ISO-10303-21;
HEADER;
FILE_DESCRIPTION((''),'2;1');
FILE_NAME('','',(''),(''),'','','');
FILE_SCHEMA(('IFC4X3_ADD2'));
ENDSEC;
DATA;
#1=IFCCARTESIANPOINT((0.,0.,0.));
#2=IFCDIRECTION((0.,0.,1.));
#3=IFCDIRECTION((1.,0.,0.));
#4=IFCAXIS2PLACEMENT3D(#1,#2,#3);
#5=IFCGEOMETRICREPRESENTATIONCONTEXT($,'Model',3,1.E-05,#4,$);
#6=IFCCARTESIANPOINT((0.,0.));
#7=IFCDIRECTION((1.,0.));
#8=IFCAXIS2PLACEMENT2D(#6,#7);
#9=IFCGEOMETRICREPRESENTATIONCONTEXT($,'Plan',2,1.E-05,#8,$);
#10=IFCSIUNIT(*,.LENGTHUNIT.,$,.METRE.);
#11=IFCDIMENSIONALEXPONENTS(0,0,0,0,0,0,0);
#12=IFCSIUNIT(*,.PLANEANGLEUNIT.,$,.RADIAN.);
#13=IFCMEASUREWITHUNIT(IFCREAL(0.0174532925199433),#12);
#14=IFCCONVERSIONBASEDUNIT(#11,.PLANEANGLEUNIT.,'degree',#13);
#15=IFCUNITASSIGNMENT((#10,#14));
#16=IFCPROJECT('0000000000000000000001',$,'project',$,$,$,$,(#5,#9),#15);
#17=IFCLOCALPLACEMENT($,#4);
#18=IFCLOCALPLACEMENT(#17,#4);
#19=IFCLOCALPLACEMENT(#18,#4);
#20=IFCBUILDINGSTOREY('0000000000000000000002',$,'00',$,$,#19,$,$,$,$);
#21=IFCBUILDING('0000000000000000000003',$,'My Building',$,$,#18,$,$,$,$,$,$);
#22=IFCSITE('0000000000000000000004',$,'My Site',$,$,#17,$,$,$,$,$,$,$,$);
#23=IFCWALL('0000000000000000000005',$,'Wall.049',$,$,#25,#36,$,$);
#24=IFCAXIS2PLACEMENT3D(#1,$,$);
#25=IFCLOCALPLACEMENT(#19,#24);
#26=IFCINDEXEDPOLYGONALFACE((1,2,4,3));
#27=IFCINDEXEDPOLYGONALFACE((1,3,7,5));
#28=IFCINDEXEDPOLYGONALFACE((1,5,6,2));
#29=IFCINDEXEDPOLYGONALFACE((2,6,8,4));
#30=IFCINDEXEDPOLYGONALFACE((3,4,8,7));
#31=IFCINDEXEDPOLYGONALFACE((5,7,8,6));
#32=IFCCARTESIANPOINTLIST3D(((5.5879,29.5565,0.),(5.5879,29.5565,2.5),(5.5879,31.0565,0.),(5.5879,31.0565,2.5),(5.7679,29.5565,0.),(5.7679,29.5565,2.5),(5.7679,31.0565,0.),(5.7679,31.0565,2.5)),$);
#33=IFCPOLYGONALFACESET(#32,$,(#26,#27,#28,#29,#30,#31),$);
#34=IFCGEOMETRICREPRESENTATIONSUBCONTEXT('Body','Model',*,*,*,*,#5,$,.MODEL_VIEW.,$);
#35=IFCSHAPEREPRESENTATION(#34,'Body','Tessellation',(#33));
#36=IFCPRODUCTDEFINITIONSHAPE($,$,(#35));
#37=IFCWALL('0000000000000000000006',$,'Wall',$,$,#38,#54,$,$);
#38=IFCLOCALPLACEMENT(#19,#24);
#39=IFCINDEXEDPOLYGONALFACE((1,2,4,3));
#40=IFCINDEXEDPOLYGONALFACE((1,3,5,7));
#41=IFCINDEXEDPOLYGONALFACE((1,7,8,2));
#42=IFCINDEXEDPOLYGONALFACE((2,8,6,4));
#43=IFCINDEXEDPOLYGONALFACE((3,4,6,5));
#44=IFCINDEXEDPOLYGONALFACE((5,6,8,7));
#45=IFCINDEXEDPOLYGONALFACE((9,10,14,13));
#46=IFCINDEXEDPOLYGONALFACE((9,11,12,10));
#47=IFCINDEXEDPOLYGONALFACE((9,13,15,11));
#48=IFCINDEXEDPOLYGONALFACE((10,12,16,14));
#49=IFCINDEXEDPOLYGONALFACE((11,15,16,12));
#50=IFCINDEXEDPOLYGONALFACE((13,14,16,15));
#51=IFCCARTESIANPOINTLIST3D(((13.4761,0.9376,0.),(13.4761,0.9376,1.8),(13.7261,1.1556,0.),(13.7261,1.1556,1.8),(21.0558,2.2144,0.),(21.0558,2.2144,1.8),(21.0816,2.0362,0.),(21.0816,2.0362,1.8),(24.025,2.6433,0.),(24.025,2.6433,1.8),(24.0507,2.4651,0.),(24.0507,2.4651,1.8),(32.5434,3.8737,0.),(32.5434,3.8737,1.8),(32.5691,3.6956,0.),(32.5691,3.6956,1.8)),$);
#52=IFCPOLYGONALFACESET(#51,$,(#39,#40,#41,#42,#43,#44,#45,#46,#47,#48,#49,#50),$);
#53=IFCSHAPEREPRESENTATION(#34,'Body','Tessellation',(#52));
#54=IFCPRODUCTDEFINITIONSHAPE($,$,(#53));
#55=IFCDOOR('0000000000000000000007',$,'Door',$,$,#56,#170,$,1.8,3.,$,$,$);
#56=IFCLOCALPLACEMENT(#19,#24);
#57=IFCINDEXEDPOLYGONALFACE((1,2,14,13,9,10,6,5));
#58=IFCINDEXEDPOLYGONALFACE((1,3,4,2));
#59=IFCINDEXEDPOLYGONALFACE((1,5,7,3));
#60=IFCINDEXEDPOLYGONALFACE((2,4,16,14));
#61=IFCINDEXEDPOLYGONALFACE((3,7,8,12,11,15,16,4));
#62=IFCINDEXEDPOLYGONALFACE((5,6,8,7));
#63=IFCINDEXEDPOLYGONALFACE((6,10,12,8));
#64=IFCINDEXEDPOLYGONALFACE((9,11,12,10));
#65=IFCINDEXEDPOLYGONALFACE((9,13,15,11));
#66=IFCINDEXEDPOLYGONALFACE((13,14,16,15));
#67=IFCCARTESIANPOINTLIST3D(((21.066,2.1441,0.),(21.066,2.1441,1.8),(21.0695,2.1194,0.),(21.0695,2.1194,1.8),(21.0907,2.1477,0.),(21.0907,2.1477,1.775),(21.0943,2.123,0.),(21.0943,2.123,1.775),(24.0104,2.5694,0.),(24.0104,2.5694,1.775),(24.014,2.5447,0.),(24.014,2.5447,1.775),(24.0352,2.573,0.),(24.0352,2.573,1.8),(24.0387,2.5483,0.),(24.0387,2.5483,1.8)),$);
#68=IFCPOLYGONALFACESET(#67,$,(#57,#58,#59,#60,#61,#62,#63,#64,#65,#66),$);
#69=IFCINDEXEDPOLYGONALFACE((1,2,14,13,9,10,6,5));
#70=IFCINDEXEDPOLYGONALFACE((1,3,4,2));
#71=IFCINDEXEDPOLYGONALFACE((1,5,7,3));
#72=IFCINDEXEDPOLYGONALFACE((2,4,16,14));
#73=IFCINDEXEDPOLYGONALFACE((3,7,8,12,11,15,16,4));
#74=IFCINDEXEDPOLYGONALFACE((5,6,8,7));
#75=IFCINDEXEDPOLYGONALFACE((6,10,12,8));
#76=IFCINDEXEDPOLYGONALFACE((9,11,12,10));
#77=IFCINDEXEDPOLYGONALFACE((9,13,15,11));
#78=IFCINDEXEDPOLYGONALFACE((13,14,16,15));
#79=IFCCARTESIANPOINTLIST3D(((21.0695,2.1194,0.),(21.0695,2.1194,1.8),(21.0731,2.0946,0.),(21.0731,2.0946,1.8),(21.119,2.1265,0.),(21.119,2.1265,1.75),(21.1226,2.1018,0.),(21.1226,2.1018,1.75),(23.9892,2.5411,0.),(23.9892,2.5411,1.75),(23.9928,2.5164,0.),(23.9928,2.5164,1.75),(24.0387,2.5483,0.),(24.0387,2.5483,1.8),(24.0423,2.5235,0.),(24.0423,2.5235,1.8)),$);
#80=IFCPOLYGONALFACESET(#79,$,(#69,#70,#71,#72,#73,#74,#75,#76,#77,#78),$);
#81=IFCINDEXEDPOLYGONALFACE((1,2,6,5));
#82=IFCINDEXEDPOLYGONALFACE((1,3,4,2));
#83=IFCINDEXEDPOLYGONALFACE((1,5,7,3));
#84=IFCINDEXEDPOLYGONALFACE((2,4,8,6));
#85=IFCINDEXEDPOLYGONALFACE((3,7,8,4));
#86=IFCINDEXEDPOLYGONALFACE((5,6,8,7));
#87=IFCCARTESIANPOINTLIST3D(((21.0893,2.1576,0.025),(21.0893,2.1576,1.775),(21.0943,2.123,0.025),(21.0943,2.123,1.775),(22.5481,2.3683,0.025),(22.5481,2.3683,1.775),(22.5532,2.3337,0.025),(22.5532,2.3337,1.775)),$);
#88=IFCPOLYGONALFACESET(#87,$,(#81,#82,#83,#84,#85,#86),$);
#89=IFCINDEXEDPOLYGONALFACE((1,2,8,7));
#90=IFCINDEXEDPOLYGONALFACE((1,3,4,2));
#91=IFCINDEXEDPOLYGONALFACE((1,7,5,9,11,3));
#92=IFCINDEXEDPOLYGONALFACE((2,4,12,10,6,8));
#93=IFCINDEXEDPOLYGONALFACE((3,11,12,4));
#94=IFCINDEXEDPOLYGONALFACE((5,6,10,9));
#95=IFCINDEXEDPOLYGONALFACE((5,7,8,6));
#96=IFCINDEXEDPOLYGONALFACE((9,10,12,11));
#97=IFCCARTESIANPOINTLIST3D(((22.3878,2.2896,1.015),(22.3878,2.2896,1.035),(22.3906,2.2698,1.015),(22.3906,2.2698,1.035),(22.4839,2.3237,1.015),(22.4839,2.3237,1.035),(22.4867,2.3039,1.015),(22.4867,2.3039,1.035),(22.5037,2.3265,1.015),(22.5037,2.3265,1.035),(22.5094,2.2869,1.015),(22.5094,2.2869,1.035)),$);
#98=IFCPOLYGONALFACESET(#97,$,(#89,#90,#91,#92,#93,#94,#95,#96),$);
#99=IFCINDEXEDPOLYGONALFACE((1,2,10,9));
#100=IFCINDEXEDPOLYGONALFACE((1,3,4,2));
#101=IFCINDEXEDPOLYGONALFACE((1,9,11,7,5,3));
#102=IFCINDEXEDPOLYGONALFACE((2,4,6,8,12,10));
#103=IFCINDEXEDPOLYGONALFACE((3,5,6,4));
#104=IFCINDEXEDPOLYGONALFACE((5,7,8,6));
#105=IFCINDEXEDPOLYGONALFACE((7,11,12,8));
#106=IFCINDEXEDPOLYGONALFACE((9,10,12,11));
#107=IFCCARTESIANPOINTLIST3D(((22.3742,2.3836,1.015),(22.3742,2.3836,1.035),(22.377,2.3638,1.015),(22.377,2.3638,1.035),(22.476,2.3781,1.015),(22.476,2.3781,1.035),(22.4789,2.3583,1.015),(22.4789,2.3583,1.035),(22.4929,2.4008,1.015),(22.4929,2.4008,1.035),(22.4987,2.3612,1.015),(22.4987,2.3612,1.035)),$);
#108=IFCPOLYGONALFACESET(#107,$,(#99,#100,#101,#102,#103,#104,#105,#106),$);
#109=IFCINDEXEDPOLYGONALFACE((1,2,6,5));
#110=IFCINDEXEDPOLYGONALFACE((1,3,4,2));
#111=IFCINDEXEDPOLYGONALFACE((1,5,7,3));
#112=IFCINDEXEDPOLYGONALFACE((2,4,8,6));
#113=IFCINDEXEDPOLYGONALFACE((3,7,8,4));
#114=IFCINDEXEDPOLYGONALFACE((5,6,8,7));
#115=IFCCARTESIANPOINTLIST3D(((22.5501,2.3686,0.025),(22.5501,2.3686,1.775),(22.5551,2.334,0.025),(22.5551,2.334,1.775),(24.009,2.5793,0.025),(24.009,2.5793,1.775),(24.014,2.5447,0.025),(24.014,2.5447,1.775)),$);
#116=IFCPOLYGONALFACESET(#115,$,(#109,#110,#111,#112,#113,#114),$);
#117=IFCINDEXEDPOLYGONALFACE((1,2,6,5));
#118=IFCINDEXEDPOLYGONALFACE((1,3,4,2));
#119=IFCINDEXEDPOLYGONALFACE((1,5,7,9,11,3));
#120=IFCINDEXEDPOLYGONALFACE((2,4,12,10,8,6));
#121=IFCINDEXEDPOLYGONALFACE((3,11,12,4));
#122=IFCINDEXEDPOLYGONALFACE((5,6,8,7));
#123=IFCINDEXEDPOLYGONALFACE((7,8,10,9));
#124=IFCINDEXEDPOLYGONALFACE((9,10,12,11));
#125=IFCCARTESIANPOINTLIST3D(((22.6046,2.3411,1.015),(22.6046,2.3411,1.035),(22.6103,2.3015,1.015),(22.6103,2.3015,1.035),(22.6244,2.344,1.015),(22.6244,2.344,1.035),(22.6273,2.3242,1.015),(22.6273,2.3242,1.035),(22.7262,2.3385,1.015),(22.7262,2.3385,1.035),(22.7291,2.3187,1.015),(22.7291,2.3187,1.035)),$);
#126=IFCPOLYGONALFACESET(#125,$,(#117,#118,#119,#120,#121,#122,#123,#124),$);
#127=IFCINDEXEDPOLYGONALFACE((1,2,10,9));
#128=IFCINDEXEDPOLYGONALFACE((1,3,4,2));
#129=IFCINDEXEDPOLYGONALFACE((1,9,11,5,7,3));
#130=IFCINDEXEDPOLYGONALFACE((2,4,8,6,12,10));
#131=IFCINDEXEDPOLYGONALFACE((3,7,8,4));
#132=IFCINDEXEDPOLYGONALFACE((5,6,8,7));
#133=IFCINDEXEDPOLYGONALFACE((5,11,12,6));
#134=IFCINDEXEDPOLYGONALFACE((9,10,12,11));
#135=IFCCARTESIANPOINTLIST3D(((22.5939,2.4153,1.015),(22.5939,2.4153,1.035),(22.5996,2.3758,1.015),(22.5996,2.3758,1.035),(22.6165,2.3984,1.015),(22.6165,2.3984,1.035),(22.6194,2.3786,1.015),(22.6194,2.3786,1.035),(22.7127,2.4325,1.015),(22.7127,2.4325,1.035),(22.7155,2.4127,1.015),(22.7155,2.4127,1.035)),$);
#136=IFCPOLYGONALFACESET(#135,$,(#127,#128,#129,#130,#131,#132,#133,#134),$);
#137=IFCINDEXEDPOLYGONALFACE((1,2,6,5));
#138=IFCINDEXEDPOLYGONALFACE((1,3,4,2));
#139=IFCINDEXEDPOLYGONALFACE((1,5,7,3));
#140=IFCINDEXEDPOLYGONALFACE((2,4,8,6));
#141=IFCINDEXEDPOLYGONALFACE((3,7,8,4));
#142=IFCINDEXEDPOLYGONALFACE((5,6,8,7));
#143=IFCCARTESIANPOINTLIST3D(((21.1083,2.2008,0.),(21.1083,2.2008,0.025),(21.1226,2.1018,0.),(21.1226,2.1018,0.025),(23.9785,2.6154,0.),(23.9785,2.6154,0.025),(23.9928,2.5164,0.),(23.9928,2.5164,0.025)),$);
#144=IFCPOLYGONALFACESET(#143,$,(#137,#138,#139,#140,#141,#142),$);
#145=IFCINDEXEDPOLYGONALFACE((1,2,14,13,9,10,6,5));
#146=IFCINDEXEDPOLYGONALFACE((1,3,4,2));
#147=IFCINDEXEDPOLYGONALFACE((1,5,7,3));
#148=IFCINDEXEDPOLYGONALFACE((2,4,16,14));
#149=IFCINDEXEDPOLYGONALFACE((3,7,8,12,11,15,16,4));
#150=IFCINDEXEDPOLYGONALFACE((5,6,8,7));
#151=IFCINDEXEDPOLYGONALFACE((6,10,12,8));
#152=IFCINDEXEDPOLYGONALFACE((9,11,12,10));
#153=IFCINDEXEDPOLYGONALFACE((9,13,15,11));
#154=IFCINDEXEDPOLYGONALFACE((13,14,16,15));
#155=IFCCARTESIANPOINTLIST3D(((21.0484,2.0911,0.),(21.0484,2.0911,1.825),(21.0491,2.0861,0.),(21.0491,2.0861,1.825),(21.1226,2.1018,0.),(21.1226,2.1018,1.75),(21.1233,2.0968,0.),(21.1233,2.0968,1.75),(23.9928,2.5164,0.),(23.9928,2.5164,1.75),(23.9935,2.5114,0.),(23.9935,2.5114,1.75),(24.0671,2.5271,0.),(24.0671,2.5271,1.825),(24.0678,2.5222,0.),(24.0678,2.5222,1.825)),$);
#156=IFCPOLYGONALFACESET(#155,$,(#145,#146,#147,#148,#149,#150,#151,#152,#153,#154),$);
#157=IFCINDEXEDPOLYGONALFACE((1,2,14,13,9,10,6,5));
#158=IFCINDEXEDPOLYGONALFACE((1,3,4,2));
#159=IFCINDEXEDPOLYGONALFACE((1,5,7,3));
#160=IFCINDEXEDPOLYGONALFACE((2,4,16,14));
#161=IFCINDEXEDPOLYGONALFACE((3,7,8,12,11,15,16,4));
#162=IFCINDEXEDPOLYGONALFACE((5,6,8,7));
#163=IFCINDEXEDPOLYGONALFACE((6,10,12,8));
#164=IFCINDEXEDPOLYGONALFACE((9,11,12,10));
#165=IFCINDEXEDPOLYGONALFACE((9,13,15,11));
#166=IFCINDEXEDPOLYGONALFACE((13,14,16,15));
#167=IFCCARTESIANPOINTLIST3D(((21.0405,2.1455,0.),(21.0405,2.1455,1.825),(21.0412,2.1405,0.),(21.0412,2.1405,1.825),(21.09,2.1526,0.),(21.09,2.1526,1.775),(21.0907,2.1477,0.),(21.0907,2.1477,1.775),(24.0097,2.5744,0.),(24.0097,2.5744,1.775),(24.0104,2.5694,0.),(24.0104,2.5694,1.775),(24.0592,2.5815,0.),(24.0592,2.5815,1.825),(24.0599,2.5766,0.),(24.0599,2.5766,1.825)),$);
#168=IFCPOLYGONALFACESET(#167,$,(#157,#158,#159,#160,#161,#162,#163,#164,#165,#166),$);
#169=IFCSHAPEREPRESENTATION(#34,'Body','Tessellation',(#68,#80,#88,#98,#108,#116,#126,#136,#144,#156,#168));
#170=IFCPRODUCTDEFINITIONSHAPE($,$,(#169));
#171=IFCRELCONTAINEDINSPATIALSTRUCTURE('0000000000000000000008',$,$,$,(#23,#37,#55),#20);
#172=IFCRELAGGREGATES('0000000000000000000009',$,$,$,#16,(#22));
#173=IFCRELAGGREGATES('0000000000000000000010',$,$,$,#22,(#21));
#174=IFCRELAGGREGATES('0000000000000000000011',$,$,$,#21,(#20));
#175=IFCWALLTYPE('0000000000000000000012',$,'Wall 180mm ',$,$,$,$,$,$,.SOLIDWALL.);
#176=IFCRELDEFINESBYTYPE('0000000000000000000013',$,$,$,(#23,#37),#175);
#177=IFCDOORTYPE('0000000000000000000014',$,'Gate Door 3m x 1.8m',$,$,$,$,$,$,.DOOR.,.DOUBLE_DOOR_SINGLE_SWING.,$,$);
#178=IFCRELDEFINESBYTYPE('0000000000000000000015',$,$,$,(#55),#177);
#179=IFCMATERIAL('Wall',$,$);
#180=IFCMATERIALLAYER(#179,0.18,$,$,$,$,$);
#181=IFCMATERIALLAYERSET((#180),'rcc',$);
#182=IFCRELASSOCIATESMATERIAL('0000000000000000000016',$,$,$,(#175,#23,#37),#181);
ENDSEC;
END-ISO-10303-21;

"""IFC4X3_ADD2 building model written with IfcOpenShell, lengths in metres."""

from ifc_helpers import new_model, entity, si_unit, converted_unit, frame, origin_with_axes, origin_2d_with_axis, place, context, subcontext, project, spatial, line, indexed_curve, outline, extrude, shape, source, transform, mapped, material, layer, layer_set, layer_usage, type_object, type_shapes, element, fill, save


model = new_model("IFC4X3_ADD2")

# Units and contexts
model_context = context("Model", 3, precision=1e-05, world=origin_with_axes())
plan_context = context("Plan", 2, precision=1e-05, world=origin_2d_with_axis())
body_context_1 = subcontext(model_context, "Body", "Model", "MODEL_VIEW")
body_context_2 = subcontext(plan_context, "Body", "Plan", "PLAN_VIEW")
ifc_project = project(units=[si_unit("LENGTHUNIT", "METRE"), converted_unit("PLANEANGLEUNIT", "degree", entity("IfcReal", 0.0174532925199433), si_unit("PLANEANGLEUNIT", "RADIAN"), dimensions=[0, 0, 0, 0, 0, 0, 0])], contexts=[model_context, plan_context])

# Site, building, storey
site_placement = place(None, origin_with_axes())
site = spatial("IfcSite", under=ifc_project, at=site_placement, Name="My Site")
building_placement = place(site_placement, origin_with_axes())
building = spatial("IfcBuilding", under=site, at=building_placement, Name="My Building")
storey_placement = place(building_placement, origin_with_axes())
storey = spatial("IfcBuildingStorey", under=building, at=storey_placement, Name="00")

# Shared definitions
ifc_material_1 = material(Name="Wall")
ifc_layer_1 = layer(ifc_material_1, 0.18)
ifc_layer_set_1 = layer_set([ifc_layer_1], Name="rcc")
wall_type_1 = type_object("IfcWallType", Name="Wall 180mm ", PredefinedType="SOLIDWALL", material=ifc_layer_set_1)

# Wall
ifc_layer_usage_1 = layer_usage(ifc_layer_set_1, "AXIS2", "POSITIVE", 0.0)
wall_1_placement = place(storey_placement, frame((5.7679, 29.5565, 0.0), z_axis=(0.0, 0.0, 1.0), x_axis=(0.0, 1.0, 0.0)))
element("IfcWall", 1, at=wall_1_placement, inside=storey, type_object=wall_type_1, material=ifc_layer_usage_1, Name="Wall.049", context=body_context_1, shape_type="SweptSolid", body=[
    extrude(outline(indexed_curve([(0.0, 0.0), (0.0, 0.18), (1.5, 0.18), (1.5, 0.0), (0.0, 0.0)], self_intersect=False)), origin_with_axes(), (0.0, 0.0, 1.0), 2.5),
])

# Wall, opening, door
ifc_layer_usage_2 = layer_usage(ifc_layer_set_1, "AXIS2", "POSITIVE", 0.0)
wall_2_placement = place(storey_placement, frame((13.7261, 0.9737, 0.0), z_axis=(0.0, 0.0, 1.0), x_axis=(0.989728, 0.142965, 0.0)))
wall_2 = element("IfcWall", 2, at=wall_2_placement, inside=storey, type_object=wall_type_1, material=ifc_layer_usage_2, Name="Wall", context=body_context_1, shape_type="SweptSolid", body=[
    extrude(outline(indexed_curve([(-0.2526, 0.0), (0.026, 0.18), (19.0386, 0.18), (19.0386, 0.0)], segments=[line(1, 2, 3, 4, 1)])), origin_with_axes(), (0.0, 0.0, 1.0), 1.8),
])
shared_shape_1 = source(origin_with_axes(), body_context_1, "Body", "SweptSolid", [
    extrude(outline(indexed_curve([(0.0, 0.0), (3.0, 0.0), (3.0, 1.8), (0.0, 1.8)], segments=[line(1, 2, 3, 4, 1)])), frame((0.0, -0.6, 0.0), z_axis=(0.0, -1.0, 0.0), x_axis=(1.0, 0.0, 0.0)), (0.0, 0.0, -1.0), 1.2),
])
opening_1_placement = place(wall_2_placement, frame((7.4318, 0.059, 0.0), z_axis=(0.0, 0.0, 1.0), x_axis=(1.0, 0.0, 0.0)))
opening_1 = element("IfcOpeningElement", 3, at=opening_1_placement, cuts=wall_2, PredefinedType="OPENING", context=body_context_1, shape_type="MappedRepresentation", body=[
    mapped(shared_shape_1, transform((0.0, 0.0, 0.0), x_axis=(1.0, 0.0, 0.0), y_axis=(0.0, 1.0, 0.0), z_axis=(0.0, 0.0, 1.0), scale=1.0)),
])
door_type_1 = type_object("IfcDoorType", Name="Gate Door 3m x 1.8m", OperationType="DOUBLE_DOOR_SINGLE_SWING", PredefinedType="DOOR")
shared_shape_2 = source(origin_with_axes(), body_context_1, "Body", "SweptSolid", [
    extrude(outline(indexed_curve([(0.0, 0.0), (0.0, 1.8), (3.0, 1.8), (3.0, 0.0), (2.975, 0.0), (2.975, 1.775), (0.025, 1.775), (0.025, 0.0)], segments=[line(1, 2, 3, 4, 5, 6, 7, 8, 1)])), frame((0.0, 0.025, 0.0), z_axis=(0.0, -1.0, 0.0), x_axis=(1.0, 0.0, 0.0)), (0.0, 0.0, -1.0), 0.025),
    extrude(outline(indexed_curve([(0.0, 0.0), (0.0, 1.8), (3.0, 1.8), (3.0, 0.0), (2.95, 0.0), (2.95, 1.75), (0.05, 1.75), (0.05, 0.0)], segments=[line(1, 2, 3, 4, 5, 6, 7, 8, 1)])), frame((0.0, 0.0, 0.0), z_axis=(0.0, -1.0, 0.0), x_axis=(1.0, 0.0, 0.0)), (0.0, 0.0, -1.0), 0.025),
    extrude(outline(indexed_curve([(0.0, 0.0), (1.474, 0.0), (1.474, 0.035), (0.0, 0.035)], segments=[line(1, 2, 3, 4, 1)])), frame((0.025, 0.025, 0.025), z_axis=(0.0, 0.0, 1.0), x_axis=(1.0, 0.0, 0.0)), (0.0, 0.0, 1.0), 1.75),
    extrude(outline(indexed_curve([(0.0, 0.0), (0.0, -0.04), (-0.12, -0.04), (-0.12, -0.02), (-0.02, -0.02), (-0.02, 0.0)], segments=[line(1, 2, 3, 4, 5, 6, 1)])), frame((1.449, 0.025, 1.015), z_axis=(0.0, 0.0, 1.0), x_axis=(1.0, 0.0, 0.0)), (0.0, 0.0, 1.0), 0.02),
    extrude(outline(indexed_curve([(0.0, 0.0), (0.0, 0.04), (-0.12, 0.04), (-0.12, 0.02), (-0.02, 0.02), (-0.02, 0.0)], segments=[line(1, 2, 3, 4, 5, 6, 1)])), frame((1.449, 0.06, 1.015), z_axis=(0.0, 0.0, 1.0), x_axis=(1.0, 0.0, 0.0)), (0.0, 0.0, 1.0), 0.02),
    extrude(outline(indexed_curve([(0.0, 0.0), (-1.474, 0.0), (-1.474, 0.035), (0.0, 0.035)], segments=[line(1, 2, 3, 4, 1)])), frame((2.975, 0.025, 0.025), z_axis=(0.0, 0.0, 1.0), x_axis=(1.0, 0.0, 0.0)), (0.0, 0.0, 1.0), 1.75),
    extrude(outline(indexed_curve([(0.0, 0.0), (0.0, -0.04), (0.12, -0.04), (0.12, -0.02), (0.02, -0.02), (0.02, 0.0)], segments=[line(1, 2, 3, 4, 5, 6, 1)])), frame((1.551, 0.025, 1.015), z_axis=(0.0, 0.0, 1.0), x_axis=(1.0, 0.0, 0.0)), (0.0, 0.0, 1.0), 0.02),
    extrude(outline(indexed_curve([(0.0, 0.0), (0.0, 0.04), (0.12, 0.04), (0.12, 0.02), (0.02, 0.02), (0.02, 0.0)], segments=[line(1, 2, 3, 4, 5, 6, 1)])), frame((1.551, 0.06, 1.015), z_axis=(0.0, 0.0, 1.0), x_axis=(1.0, 0.0, 0.0)), (0.0, 0.0, 1.0), 0.02),
    extrude(outline(indexed_curve([(0.0, 0.0), (2.9, 0.0), (2.9, 0.1), (0.0, 0.1)], segments=[line(1, 2, 3, 4, 1)])), frame((0.05, 0.0, 0.0), z_axis=(0.0, 0.0, 1.0), x_axis=(1.0, 0.0, 0.0)), (0.0, 0.0, 1.0), 0.025),
    extrude(outline(indexed_curve([(0.0, 0.0), (0.0, 1.825), (3.05, 1.825), (3.05, 0.0), (2.975, 0.0), (2.975, 1.75), (0.075, 1.75), (0.075, 0.0)], segments=[line(1, 2, 3, 4, 5, 6, 7, 8, 1)])), frame((-0.025, -0.005, 0.0), z_axis=(0.0, -1.0, 0.0), x_axis=(1.0, 0.0, 0.0)), (0.0, 0.0, -1.0), 0.005),
    extrude(outline(indexed_curve([(0.0, 0.0), (0.0, 1.825), (3.05, 1.825), (3.05, 0.0), (3.0, 0.0), (3.0, 1.775), (0.05, 1.775), (0.05, 0.0)], segments=[line(1, 2, 3, 4, 5, 6, 7, 8, 1)])), frame((-0.025, 0.05, 0.0), z_axis=(0.0, -1.0, 0.0), x_axis=(1.0, 0.0, 0.0)), (0.0, 0.0, -1.0), 0.005),
])
shared_shape_3 = source(origin_with_axes(), body_context_2, "Body", "Curve2D", [
    entity("IfcIndexedPolyCurve", entity("IfcCartesianPointList2D", [[0.0, 0.0], [0.0, 0.05], [0.025, 0.05], [0.025, 0.025], [0.05, 0.025], [0.05, 0.0]]), [entity("IfcLineIndex", [1, 2, 3, 4, 5, 6, 1])]),
    entity("IfcIndexedPolyCurve", entity("IfcCartesianPointList2D", [[3.0, 0.0], [3.0, 0.05], [2.975, 0.05], [2.975, 0.025], [2.95, 0.025], [2.95, 0.0]]), [entity("IfcLineIndex", [1, 2, 3, 4, 5, 6, 1])]),
    entity("IfcTrimmedCurve", entity("IfcEllipse", entity("IfcAxis2Placement2D", entity("IfcCartesianPoint", [0.06, 0.05]), entity("IfcDirection", [1.0, 0.0])), 1.44, 1.475), [entity("IfcCartesianPoint", [1.5, 0.05])], [entity("IfcCartesianPoint", [0.06, 1.525])], True, "CARTESIAN"),
    entity("IfcIndexedPolyCurve", entity("IfcCartesianPointList2D", [[0.025, 0.05], [0.06, 0.05], [0.06, 1.525], [0.025, 1.525]]), [entity("IfcLineIndex", [1, 2, 3, 4, 1])]),
    entity("IfcTrimmedCurve", entity("IfcEllipse", entity("IfcAxis2Placement2D", entity("IfcCartesianPoint", [2.94, 0.05]), entity("IfcDirection", [1.0, 0.0])), 1.44, 1.475), [entity("IfcCartesianPoint", [2.94, 1.525])], [entity("IfcCartesianPoint", [1.5, 0.05])], True, "CARTESIAN"),
    entity("IfcIndexedPolyCurve", entity("IfcCartesianPointList2D", [[2.975, 0.05], [2.94, 0.05], [2.94, 1.525], [2.975, 1.525]]), [entity("IfcLineIndex", [1, 2, 3, 4, 1])]),
])
type_shapes(door_type_1, [shared_shape_2, shared_shape_3])
door_1_placement = place(opening_1_placement, frame((0.0, 0.0, 0.0), z_axis=(0.0, 0.0, 1.0), x_axis=(1.0, 0.0, 0.0)))
door_1 = element("IfcDoor", 4, at=door_1_placement, inside=storey, type_object=door_type_1, Name="Door", OverallHeight=1.8, OverallWidth=3.0, shapes=[
    shape(body_context_1, "Body", "MappedRepresentation", [mapped(shared_shape_2, transform((0.0, 0.0, 0.0), x_axis=(1.0, 0.0, 0.0), y_axis=(0.0, 1.0, 0.0), z_axis=(0.0, 0.0, 1.0), scale=1.0))]),
    shape(body_context_2, "Body", "MappedRepresentation", [mapped(shared_shape_3, transform((0.0, 0.0, 0.0), x_axis=(1.0, 0.0, 0.0), y_axis=(0.0, 1.0, 0.0), z_axis=(0.0, 0.0, 1.0), scale=1.0))]),
])
fill(opening_1, door_1)

save(model, "model.ifc")
